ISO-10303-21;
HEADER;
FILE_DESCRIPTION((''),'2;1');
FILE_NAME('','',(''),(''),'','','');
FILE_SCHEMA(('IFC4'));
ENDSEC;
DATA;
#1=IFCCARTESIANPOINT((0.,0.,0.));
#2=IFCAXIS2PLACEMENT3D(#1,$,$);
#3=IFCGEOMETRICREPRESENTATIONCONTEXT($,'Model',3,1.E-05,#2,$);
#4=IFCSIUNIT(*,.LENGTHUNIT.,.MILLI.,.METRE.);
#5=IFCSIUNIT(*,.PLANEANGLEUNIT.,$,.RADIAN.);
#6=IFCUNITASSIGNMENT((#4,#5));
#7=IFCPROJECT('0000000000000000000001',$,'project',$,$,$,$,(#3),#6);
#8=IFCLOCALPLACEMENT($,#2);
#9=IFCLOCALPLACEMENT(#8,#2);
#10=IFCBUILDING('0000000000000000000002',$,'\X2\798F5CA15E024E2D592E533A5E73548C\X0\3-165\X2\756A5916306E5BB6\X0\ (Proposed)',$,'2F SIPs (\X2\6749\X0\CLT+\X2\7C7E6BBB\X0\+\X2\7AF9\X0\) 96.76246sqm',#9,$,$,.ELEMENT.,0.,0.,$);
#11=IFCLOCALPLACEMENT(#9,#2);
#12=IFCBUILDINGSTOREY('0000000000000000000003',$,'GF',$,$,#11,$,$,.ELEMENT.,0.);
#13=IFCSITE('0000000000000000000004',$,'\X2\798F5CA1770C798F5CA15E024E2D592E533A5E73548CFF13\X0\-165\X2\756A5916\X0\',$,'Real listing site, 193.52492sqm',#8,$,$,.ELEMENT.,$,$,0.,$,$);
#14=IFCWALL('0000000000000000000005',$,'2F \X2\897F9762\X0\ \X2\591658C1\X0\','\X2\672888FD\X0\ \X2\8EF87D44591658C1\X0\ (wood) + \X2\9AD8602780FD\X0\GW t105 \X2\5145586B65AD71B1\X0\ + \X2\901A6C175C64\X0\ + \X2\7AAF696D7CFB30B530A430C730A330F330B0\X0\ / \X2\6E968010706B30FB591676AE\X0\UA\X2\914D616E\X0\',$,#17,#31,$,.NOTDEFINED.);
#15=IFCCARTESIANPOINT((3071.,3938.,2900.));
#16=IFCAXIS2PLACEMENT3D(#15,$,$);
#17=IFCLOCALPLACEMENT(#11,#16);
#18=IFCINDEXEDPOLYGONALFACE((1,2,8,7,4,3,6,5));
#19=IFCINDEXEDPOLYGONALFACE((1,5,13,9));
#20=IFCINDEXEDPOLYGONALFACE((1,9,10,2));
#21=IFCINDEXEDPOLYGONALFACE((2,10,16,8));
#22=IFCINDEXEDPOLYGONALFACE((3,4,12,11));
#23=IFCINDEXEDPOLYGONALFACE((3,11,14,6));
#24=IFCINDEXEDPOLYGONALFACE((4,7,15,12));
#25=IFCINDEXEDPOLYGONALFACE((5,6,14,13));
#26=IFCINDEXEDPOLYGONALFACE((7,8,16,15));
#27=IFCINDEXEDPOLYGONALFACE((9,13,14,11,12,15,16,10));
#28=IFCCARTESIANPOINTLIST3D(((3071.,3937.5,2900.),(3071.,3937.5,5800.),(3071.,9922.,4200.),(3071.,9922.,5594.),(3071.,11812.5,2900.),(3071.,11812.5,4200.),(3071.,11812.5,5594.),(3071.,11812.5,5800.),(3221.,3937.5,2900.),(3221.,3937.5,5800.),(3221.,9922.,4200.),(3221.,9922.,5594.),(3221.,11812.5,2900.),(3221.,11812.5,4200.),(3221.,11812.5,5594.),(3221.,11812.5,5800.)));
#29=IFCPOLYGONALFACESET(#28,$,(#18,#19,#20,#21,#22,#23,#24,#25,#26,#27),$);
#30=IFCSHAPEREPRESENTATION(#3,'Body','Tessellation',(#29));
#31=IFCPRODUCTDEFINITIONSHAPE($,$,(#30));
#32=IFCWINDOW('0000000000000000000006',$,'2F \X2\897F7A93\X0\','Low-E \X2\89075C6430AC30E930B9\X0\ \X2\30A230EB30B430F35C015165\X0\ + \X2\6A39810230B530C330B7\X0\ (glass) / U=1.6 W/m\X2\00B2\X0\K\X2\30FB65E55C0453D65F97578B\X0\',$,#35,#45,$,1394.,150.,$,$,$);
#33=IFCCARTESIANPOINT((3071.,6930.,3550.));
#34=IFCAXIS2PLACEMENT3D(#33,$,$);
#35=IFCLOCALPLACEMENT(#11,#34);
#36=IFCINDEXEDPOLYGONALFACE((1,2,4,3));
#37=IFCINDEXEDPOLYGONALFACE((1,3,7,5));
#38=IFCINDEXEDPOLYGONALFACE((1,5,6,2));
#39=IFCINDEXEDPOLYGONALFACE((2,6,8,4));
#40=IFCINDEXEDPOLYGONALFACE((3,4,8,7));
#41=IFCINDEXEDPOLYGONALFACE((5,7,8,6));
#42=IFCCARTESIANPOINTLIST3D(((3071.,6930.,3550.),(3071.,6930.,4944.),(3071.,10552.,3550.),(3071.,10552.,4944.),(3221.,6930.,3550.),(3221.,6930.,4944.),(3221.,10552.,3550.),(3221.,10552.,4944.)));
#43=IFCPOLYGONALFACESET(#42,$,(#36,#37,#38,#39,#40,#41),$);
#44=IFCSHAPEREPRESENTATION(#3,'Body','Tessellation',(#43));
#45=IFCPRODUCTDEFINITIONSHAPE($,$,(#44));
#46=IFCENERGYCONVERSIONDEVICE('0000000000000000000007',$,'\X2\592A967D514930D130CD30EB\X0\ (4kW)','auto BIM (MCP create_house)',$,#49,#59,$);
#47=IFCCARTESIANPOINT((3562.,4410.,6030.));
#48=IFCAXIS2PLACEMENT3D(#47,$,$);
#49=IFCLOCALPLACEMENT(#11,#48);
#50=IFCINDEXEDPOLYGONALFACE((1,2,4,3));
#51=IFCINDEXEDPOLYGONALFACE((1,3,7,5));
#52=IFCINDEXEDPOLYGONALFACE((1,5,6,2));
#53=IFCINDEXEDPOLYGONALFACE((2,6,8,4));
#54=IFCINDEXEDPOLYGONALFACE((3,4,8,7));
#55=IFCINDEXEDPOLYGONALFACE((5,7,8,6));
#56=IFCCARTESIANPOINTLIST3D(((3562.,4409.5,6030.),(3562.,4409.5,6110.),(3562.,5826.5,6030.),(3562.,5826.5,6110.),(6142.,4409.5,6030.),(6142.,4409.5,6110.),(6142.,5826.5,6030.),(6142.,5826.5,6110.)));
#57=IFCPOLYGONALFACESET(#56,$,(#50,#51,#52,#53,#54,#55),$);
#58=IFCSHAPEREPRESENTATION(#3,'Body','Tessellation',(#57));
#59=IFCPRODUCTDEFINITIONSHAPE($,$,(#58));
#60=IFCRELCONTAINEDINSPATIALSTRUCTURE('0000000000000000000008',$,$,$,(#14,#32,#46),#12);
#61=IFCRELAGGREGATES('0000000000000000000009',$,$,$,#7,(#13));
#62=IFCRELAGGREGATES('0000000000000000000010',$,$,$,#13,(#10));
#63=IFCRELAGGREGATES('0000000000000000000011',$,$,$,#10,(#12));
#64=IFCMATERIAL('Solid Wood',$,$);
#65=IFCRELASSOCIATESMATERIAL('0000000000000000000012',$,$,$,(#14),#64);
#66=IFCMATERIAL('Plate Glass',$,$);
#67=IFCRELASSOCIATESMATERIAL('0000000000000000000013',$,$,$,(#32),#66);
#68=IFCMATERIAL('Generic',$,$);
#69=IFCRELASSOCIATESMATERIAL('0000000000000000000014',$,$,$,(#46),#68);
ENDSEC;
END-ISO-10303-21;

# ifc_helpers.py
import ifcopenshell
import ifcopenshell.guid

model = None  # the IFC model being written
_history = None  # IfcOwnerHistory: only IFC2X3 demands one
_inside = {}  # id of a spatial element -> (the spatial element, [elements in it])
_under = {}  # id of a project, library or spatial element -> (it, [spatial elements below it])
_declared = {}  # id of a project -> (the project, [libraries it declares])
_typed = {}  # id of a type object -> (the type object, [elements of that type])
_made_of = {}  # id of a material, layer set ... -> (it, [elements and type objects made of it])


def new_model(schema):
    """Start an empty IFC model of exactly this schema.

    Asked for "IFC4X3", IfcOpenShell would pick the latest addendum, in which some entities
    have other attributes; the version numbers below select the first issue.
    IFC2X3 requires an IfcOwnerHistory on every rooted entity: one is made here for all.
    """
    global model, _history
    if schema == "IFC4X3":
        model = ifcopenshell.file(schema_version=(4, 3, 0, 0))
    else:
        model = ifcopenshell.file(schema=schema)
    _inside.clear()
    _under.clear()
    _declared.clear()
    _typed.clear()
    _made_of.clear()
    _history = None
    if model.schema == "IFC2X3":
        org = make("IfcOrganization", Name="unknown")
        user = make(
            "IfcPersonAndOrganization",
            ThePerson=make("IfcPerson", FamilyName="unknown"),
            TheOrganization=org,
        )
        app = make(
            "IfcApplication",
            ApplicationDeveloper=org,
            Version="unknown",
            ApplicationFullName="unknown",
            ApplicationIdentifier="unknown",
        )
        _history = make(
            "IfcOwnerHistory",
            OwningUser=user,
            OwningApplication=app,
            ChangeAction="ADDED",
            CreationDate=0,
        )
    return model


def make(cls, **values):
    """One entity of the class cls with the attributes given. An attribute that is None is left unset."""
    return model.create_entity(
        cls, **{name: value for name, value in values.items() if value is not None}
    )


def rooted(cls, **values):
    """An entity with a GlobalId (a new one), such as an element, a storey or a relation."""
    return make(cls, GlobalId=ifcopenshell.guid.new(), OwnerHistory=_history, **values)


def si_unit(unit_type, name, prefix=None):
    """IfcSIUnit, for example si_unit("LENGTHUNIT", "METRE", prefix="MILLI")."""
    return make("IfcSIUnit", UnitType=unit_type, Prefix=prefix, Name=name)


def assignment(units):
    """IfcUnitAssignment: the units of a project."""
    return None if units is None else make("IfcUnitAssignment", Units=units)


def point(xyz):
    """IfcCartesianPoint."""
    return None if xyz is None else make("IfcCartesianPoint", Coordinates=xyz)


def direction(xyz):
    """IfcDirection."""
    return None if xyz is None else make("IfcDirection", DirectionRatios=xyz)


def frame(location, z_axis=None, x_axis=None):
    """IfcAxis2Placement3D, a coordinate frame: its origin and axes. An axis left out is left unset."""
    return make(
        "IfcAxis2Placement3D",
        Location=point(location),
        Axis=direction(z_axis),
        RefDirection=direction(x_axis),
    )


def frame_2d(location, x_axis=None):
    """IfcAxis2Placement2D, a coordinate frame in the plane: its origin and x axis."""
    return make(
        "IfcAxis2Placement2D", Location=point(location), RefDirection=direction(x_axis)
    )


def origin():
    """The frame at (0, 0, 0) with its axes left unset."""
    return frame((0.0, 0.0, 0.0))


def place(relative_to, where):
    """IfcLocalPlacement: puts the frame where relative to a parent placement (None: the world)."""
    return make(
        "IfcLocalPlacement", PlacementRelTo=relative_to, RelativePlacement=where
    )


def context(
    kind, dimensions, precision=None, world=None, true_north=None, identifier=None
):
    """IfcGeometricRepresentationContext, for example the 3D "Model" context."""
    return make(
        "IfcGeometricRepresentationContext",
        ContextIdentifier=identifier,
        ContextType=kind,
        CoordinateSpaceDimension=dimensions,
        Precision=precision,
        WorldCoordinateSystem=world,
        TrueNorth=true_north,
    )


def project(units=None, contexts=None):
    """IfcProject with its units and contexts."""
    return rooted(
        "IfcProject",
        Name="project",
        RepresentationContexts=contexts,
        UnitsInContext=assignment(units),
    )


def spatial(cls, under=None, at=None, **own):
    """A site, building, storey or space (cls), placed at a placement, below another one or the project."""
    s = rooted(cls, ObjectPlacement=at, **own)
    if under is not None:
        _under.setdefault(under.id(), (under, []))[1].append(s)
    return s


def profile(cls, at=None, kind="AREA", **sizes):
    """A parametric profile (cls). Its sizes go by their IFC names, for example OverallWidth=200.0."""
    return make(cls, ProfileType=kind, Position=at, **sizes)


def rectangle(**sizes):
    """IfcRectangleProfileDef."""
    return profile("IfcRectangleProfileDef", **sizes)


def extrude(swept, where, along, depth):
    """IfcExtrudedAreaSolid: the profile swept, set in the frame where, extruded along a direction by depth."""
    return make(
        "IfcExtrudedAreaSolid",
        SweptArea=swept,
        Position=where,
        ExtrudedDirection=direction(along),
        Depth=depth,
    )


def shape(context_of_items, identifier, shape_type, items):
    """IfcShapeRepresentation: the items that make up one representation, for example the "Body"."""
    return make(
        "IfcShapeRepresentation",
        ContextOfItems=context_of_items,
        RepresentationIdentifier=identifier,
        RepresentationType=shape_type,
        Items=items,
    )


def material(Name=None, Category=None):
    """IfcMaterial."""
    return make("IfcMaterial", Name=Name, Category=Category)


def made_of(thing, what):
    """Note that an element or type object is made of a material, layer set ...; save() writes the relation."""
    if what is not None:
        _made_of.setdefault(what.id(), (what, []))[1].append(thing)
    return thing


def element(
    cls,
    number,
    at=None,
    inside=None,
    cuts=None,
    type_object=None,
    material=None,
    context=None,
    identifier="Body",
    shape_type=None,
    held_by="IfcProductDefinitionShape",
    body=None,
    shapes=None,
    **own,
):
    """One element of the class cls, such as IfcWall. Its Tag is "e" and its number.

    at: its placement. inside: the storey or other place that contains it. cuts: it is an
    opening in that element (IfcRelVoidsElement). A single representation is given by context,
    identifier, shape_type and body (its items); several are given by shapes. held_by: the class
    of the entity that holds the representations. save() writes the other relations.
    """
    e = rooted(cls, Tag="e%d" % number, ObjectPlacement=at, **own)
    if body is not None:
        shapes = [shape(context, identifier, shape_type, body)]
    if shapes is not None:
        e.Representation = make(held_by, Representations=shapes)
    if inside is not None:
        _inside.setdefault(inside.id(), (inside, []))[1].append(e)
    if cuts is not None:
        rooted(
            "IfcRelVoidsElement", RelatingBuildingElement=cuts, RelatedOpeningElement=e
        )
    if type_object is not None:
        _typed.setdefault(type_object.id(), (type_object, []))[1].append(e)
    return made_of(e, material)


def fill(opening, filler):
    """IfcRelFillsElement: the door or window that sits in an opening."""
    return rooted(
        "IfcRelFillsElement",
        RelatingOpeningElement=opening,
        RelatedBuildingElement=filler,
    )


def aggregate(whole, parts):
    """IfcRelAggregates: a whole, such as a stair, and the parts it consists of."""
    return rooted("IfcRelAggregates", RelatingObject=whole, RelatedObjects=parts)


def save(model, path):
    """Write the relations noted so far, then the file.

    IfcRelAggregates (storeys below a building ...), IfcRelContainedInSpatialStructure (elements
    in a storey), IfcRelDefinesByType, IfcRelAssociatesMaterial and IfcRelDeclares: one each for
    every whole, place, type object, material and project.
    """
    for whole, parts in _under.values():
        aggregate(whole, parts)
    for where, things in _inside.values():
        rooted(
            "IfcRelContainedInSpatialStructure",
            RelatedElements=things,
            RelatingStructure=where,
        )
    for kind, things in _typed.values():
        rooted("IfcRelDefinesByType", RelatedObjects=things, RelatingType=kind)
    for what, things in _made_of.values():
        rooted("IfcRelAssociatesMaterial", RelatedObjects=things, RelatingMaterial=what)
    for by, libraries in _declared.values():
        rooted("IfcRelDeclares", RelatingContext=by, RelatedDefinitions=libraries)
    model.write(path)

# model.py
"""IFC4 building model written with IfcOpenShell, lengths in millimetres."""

from ifc_helpers import new_model, si_unit, frame, frame_2d, origin, place, context, project, spatial, rectangle, extrude, material, element, fill, save


model = new_model("IFC4")

# Units and contexts
model_context = context("Model", 3, precision=1e-05, world=origin())
ifc_project = project(units=[si_unit("LENGTHUNIT", "METRE", prefix="MILLI"), si_unit("PLANEANGLEUNIT", "RADIAN")], contexts=[model_context])

# Site, building, storey
site_placement = place(None, origin())
site = spatial("IfcSite", under=ifc_project, at=site_placement, Name="福岡県福岡市中央区平和３-165番外", ObjectType="Real listing site, 193.52492sqm", CompositionType="ELEMENT", RefElevation=0.0)
building_placement = place(site_placement, origin())
building = spatial("IfcBuilding", under=site, at=building_placement, Name="福岡市中央区平和3-165番外の家 (Proposed)", ObjectType="2F SIPs (杉CLT+籾殻+竹) 96.76246sqm", CompositionType="ELEMENT", ElevationOfRefHeight=0.0, ElevationOfTerrain=0.0)
storey_placement = place(building_placement, origin())
storey = spatial("IfcBuildingStorey", under=building, at=storey_placement, Name="GF", CompositionType="ELEMENT", Elevation=0.0)

# Shared definitions
ifc_material_1 = material(Name="Solid Wood")

# Shared definitions
ifc_material_2 = material(Name="Plate Glass")

# Wall, opening, window
wall_1_placement = place(storey_placement, frame((3071.0, 3938.0, 2900.0)))
wall_1 = element("IfcWall", 1, at=wall_1_placement, inside=storey, material=ifc_material_1, Name="2F 西面 外壁", Description="木製 軸組外壁 (wood) + 高性能GW t105 充填断熱 + 通気層 + 窯業系サイディング / 準耐火・外皮UA配慮", PredefinedType="NOTDEFINED", context=model_context, shape_type="SweptSolid", body=[
    extrude(rectangle(XDim=150.0, YDim=7875.0, at=frame_2d((75.0, 3937.0))), frame((3071.0, 3938.0, 2900.0)), (0.0, 0.0, 1.0), 2900.0),
])
opening_1_placement = place(storey_placement, frame((3071.0, 6930.0, 3550.0)))
opening_1 = element("IfcOpeningElement", 2, at=opening_1_placement, cuts=wall_1, PredefinedType="NOTDEFINED", context=model_context, shape_type="SweptSolid", body=[
    extrude(rectangle(XDim=150.0, YDim=3622.0, at=frame_2d((75.0, 1811.0))), frame((3071.0, 6930.0, 3550.0)), (0.0, 0.0, 1.0), 1394.0),
])
window_1_placement = place(storey_placement, frame((3071.0, 6930.0, 3550.0)))
window_1 = element("IfcWindow", 3, at=window_1_placement, inside=storey, material=ifc_material_2, Name="2F 西窓", Description="Low-E 複層ガラス アルゴン封入 + 樹脂サッシ (glass) / U=1.6 W/m²K・日射取得型", OverallHeight=1394.0, OverallWidth=150.0, context=model_context, shape_type="SweptSolid", body=[
    extrude(rectangle(XDim=150.0, YDim=3622.0, at=frame_2d((75.0, 1811.0))), frame((3071.0, 6930.0, 3550.0)), (0.0, 0.0, 1.0), 1394.0),
])
fill(opening_1, window_1)

# Shared definitions
ifc_material_3 = material(Name="Generic")

# Energy conversion device
energy_conversion_device_placement = place(storey_placement, frame((3562.0, 4410.0, 6030.0)))
element("IfcEnergyConversionDevice", 4, at=energy_conversion_device_placement, inside=storey, material=ifc_material_3, Name="太陽光パネル (4kW)", Description="auto BIM (MCP create_house)", context=model_context, shape_type="SweptSolid", body=[
    extrude(rectangle(XDim=2580.0, YDim=1417.0, at=frame_2d((1290.0, 708.0))), frame((3562.0, 4410.0, 6030.0)), (0.0, 0.0, 1.0), 80.0),
])

save(model, "model.ifc")
